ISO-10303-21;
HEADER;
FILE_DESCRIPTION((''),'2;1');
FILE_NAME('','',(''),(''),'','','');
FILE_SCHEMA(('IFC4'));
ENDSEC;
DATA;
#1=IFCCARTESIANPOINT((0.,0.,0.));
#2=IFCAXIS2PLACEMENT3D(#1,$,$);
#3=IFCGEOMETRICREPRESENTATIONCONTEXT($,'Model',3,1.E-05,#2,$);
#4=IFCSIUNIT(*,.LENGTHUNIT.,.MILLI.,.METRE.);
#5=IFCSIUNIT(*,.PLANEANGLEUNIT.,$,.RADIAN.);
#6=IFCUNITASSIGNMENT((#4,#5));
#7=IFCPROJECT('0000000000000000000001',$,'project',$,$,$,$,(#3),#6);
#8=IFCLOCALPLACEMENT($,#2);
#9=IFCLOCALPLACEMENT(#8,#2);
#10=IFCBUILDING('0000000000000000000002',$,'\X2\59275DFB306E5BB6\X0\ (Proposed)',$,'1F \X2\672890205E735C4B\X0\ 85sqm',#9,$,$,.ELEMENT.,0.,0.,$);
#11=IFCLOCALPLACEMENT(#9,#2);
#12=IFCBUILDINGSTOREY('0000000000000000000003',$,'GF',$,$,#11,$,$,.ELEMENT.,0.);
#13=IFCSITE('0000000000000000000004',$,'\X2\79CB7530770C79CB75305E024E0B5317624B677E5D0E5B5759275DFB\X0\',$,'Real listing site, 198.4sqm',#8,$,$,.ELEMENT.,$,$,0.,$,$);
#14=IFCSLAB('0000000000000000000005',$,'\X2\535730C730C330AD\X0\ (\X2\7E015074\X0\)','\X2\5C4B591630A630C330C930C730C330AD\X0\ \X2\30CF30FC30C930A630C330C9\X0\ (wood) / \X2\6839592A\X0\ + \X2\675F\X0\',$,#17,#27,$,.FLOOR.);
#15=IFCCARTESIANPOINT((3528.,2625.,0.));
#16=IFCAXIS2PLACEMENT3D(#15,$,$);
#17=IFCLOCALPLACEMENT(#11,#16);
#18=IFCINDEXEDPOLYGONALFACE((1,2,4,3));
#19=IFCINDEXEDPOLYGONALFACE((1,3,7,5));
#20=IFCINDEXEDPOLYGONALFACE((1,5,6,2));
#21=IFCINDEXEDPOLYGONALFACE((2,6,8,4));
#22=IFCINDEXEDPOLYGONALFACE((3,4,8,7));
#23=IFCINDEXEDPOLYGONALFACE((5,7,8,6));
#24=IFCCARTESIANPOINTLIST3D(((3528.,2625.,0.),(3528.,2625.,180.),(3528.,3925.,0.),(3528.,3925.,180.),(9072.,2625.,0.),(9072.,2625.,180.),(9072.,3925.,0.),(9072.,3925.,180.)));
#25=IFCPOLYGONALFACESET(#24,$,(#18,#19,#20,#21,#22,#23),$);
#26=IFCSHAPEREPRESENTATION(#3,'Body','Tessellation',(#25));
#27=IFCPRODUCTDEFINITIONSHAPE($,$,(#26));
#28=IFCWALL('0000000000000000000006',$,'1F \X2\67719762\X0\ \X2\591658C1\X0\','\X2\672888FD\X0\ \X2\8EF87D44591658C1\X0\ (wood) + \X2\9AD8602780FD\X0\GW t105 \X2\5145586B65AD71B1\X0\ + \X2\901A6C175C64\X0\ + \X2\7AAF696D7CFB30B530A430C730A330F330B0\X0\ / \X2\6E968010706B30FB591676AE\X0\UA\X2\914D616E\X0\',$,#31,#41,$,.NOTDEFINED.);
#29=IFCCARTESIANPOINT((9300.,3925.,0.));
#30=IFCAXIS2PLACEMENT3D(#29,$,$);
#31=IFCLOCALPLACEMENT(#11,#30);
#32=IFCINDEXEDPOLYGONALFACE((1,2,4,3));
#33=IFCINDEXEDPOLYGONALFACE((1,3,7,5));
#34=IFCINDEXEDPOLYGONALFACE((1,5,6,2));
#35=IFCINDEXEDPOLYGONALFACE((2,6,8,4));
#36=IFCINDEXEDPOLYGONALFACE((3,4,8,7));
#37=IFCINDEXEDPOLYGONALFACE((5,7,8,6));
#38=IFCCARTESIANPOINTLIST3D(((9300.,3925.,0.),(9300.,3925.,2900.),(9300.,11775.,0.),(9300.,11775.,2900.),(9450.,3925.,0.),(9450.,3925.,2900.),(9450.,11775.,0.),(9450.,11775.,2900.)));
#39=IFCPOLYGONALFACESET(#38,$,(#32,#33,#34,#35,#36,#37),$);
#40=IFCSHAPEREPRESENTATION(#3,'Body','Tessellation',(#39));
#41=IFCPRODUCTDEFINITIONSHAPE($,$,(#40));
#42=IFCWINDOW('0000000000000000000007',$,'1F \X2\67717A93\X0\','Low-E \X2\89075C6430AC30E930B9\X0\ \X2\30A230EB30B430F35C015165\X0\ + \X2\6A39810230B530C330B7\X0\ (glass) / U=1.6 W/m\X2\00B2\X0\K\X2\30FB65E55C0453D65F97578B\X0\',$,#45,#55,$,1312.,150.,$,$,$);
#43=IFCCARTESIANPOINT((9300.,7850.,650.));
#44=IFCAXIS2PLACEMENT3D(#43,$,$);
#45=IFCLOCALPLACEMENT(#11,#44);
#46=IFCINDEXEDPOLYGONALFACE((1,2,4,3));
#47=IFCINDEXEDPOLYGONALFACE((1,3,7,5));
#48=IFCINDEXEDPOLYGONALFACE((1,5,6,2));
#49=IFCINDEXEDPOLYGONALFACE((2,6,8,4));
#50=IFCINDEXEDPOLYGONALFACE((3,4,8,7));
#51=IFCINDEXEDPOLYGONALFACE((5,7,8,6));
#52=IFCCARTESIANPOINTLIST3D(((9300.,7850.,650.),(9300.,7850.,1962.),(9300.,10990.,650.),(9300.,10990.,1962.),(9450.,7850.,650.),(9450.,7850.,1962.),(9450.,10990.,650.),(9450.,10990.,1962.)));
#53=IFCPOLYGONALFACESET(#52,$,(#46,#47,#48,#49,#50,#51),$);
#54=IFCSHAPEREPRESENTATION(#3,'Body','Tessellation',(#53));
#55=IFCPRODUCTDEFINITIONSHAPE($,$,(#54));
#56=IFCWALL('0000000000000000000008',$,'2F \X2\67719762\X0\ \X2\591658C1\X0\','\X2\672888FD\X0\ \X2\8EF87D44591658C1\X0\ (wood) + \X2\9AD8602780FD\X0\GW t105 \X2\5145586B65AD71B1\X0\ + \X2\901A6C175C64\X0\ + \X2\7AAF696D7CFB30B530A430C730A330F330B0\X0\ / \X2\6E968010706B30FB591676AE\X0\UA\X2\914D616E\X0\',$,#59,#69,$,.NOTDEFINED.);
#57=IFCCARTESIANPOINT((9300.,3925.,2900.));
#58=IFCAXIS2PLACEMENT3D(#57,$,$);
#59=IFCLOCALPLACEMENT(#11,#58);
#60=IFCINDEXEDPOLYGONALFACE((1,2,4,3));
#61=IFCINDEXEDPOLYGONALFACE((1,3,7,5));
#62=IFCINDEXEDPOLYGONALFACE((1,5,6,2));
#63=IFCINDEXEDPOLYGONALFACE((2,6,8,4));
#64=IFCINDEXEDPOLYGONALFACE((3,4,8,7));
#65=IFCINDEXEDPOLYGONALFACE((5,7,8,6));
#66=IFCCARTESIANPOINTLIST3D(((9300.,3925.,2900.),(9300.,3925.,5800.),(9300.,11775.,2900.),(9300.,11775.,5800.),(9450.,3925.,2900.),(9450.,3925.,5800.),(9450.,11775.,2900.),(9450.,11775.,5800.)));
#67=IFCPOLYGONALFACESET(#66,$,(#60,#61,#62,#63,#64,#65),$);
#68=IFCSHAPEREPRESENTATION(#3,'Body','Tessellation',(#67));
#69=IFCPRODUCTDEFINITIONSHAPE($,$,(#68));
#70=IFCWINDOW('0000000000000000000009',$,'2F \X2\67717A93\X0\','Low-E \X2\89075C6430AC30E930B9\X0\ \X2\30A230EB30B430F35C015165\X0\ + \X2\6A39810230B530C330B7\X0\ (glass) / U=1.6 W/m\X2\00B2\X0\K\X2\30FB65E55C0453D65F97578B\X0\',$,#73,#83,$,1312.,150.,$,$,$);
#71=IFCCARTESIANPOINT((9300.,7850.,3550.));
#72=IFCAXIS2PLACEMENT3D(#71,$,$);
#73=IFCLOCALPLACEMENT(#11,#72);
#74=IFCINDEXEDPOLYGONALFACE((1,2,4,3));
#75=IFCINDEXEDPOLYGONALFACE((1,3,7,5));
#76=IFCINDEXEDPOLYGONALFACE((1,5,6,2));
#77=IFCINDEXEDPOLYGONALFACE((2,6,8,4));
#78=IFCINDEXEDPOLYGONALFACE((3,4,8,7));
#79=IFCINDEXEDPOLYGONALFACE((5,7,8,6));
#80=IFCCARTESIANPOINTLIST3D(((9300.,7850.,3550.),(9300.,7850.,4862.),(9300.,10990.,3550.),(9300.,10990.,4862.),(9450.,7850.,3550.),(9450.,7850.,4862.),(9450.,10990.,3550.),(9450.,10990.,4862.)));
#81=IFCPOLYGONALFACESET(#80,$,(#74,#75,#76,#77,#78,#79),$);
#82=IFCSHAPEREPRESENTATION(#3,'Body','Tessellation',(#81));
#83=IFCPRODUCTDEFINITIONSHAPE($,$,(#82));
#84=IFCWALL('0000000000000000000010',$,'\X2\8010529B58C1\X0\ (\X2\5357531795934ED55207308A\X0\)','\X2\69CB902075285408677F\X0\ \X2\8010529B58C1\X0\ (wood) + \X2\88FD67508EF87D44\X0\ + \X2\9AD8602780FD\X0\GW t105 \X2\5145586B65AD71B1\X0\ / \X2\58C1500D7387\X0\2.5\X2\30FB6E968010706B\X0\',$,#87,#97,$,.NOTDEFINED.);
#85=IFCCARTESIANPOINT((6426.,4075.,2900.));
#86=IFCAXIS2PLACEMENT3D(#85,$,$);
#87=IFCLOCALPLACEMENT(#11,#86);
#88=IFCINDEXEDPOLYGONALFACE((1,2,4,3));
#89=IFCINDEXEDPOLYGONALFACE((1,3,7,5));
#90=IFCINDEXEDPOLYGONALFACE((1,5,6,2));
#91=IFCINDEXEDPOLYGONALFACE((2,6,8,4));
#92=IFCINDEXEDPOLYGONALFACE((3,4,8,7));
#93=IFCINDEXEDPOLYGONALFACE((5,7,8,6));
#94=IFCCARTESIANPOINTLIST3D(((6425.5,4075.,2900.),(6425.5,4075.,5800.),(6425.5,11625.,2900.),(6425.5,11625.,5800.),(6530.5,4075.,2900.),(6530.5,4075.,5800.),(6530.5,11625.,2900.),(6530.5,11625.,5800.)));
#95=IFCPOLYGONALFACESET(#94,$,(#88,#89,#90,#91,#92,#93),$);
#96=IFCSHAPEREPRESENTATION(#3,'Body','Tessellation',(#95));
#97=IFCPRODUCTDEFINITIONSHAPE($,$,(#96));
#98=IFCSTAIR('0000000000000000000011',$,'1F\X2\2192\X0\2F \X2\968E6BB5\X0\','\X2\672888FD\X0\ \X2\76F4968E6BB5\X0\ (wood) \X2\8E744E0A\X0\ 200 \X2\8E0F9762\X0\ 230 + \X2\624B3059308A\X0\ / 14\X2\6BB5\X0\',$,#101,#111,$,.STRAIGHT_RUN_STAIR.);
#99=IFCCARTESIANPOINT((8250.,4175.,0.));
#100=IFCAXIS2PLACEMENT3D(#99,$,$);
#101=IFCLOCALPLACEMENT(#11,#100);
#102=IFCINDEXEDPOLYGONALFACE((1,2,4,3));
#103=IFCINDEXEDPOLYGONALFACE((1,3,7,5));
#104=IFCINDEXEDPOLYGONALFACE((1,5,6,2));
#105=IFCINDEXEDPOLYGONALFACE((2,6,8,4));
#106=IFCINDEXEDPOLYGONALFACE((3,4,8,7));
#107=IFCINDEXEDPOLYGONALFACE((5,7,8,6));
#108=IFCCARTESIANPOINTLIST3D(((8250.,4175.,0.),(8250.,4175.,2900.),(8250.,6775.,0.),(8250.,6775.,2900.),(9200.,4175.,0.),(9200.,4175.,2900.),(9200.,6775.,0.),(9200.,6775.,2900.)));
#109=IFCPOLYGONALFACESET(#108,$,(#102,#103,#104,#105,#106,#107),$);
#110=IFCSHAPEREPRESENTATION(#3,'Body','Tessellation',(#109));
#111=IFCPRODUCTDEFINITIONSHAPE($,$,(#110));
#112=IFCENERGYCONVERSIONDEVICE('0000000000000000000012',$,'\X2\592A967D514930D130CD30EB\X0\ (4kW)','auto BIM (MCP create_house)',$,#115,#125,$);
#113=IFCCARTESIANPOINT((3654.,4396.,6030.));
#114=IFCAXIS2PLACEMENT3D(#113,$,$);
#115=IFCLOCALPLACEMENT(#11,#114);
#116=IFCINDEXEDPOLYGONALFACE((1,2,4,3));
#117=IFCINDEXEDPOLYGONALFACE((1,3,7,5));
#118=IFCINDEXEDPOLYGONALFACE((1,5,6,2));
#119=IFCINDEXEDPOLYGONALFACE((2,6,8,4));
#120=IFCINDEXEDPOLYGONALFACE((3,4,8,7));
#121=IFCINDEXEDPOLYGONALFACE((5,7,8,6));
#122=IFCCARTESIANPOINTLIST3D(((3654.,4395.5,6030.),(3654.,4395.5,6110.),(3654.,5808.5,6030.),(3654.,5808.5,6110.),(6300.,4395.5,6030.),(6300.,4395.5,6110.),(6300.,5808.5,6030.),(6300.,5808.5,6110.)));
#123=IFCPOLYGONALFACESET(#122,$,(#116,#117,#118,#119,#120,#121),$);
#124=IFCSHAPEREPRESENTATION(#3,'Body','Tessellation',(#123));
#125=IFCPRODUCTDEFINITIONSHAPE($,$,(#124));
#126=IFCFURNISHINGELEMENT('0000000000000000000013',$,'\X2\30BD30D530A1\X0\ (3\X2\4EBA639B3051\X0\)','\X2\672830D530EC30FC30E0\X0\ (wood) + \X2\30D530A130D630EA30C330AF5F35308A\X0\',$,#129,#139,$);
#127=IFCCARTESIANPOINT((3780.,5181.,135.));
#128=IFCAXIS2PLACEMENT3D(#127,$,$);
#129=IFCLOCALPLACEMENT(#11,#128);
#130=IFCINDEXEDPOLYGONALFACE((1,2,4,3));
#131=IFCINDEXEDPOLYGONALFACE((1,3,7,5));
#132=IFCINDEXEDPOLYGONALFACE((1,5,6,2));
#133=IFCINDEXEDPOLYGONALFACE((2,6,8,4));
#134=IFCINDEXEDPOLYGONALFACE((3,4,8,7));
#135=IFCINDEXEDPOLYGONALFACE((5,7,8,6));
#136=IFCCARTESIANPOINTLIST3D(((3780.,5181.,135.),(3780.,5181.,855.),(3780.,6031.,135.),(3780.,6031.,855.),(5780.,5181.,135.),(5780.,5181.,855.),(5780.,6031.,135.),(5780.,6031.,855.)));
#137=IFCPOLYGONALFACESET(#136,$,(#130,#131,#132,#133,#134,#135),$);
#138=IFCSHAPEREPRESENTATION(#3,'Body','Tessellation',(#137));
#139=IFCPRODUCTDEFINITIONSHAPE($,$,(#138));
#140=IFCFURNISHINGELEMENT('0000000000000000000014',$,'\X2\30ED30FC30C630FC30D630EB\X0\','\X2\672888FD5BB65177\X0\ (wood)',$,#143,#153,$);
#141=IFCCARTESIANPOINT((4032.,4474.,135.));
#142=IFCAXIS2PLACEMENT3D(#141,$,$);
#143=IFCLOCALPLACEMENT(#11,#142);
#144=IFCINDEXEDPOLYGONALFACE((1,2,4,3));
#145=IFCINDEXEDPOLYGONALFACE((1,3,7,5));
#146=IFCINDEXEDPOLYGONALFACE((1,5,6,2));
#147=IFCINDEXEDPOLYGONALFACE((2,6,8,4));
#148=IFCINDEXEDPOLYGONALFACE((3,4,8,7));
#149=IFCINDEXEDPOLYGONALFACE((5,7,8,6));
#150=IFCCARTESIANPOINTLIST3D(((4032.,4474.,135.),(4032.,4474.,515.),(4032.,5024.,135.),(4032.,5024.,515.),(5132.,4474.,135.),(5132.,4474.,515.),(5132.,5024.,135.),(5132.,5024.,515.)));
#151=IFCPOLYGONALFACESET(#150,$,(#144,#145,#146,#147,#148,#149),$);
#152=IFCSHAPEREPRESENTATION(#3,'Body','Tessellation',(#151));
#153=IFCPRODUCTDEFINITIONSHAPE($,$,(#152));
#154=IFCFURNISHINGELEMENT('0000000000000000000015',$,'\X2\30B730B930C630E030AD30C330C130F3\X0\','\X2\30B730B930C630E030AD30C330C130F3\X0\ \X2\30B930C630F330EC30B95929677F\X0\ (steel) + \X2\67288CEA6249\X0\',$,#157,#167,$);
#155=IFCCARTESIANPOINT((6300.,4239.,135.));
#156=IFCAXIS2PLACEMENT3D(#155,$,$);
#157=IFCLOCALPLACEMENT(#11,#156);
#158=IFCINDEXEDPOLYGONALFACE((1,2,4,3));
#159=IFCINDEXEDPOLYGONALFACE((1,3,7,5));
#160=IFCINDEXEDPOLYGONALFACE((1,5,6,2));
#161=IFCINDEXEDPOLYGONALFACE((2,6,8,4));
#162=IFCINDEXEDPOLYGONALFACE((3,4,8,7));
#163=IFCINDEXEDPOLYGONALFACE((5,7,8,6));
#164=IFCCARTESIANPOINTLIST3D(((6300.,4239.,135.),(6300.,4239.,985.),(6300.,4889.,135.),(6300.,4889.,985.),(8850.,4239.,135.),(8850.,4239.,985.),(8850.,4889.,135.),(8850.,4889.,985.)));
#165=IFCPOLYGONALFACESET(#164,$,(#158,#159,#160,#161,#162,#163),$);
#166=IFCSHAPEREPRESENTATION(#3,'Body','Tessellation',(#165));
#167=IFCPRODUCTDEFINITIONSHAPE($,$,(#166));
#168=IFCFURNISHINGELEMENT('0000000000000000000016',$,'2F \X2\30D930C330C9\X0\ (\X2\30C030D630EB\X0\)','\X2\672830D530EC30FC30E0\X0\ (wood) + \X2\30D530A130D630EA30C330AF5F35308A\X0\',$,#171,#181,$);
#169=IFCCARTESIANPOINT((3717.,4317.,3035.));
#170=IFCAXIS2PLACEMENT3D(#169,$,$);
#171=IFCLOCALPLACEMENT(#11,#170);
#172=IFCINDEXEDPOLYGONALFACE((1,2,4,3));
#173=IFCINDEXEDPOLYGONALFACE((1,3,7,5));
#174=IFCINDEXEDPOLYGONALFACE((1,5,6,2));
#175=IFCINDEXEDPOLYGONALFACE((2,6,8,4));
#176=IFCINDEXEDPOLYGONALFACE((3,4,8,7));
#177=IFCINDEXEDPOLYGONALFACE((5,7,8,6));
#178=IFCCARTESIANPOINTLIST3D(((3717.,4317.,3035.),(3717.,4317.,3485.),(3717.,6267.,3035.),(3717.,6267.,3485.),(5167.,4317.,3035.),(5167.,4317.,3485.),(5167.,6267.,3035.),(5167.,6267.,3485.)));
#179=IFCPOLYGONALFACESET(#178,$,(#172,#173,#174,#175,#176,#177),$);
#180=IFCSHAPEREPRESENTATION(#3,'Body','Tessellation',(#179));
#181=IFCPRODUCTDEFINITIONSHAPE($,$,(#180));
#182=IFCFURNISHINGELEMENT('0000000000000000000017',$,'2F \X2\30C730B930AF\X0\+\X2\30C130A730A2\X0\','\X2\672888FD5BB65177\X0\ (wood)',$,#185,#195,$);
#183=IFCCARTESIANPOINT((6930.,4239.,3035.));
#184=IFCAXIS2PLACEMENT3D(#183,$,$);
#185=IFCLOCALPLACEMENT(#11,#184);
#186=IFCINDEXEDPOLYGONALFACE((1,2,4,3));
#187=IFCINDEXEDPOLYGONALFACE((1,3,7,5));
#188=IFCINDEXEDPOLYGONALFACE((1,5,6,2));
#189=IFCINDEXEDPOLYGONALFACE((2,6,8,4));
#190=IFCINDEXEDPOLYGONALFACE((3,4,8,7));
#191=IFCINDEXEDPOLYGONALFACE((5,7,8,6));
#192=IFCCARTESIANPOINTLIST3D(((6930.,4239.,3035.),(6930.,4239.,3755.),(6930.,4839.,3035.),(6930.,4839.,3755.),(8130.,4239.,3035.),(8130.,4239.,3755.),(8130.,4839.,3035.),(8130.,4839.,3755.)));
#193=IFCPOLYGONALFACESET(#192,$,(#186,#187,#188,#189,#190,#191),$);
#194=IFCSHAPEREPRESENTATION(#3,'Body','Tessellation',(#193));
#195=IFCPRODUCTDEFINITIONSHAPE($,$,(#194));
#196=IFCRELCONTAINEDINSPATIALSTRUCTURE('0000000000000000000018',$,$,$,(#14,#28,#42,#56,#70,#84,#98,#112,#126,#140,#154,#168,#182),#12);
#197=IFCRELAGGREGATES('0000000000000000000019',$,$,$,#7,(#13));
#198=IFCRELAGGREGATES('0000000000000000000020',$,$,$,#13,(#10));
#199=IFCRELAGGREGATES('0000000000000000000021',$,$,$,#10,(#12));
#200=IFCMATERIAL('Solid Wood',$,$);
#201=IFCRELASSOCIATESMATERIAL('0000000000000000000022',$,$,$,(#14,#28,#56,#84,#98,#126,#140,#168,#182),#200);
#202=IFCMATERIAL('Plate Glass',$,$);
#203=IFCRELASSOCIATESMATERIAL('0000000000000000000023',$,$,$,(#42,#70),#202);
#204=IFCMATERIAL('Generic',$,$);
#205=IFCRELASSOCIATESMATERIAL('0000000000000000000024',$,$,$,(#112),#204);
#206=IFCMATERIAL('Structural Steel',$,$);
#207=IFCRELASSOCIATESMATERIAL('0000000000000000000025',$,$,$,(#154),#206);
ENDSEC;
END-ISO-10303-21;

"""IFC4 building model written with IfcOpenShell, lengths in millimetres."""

from ifc_helpers import new_model, si_unit, frame, frame_2d, origin, place, context, project, spatial, rectangle, extrude, material, element, fill, save


model = new_model("IFC4")

# Units and contexts
model_context = context("Model", 3, precision=1e-05, world=origin())
ifc_project = project(units=[si_unit("LENGTHUNIT", "METRE", prefix="MILLI"), si_unit("PLANEANGLEUNIT", "RADIAN")], contexts=[model_context])

# Site, building, storey
site_placement = place(None, origin())
site = spatial("IfcSite", under=ifc_project, at=site_placement, Name="秋田県秋田市下北手松崎字大巻", ObjectType="Real listing site, 198.4sqm", CompositionType="ELEMENT", RefElevation=0.0)
building_placement = place(site_placement, origin())
building = spatial("IfcBuilding", under=site, at=building_placement, Name="大巻の家 (Proposed)", ObjectType="1F 木造平屋 85sqm", CompositionType="ELEMENT", ElevationOfRefHeight=0.0, ElevationOfTerrain=0.0)
storey_placement = place(building_placement, origin())
storey = spatial("IfcBuildingStorey", under=building, at=storey_placement, Name="GF", CompositionType="ELEMENT", Elevation=0.0)

# Slab
ifc_material_1 = material(Name="Solid Wood")
slab_placement = place(storey_placement, frame((3528.0, 2625.0, 0.0)))
element("IfcSlab", 1, at=slab_placement, inside=storey, material=ifc_material_1, Name="南デッキ (縁側)", Description="屋外ウッドデッキ ハードウッド (wood) / 根太 + 束", PredefinedType="FLOOR", context=model_context, shape_type="SweptSolid", body=[
    extrude(rectangle(XDim=5544.0, YDim=1300.0, at=frame_2d((2772.0, 650.0))), frame((3528.0, 2625.0, 0.0)), (0.0, 0.0, 1.0), 180.0),
])

# Wall, opening, window
wall_1_placement = place(storey_placement, frame((9300.0, 3925.0, 0.0)))
wall_1 = element("IfcWall", 2, at=wall_1_placement, inside=storey, material=ifc_material_1, Name="1F 東面 外壁", Description="木製 軸組外壁 (wood) + 高性能GW t105 充填断熱 + 通気層 + 窯業系サイディング / 準耐火・外皮UA配慮", PredefinedType="NOTDEFINED", context=model_context, shape_type="SweptSolid", body=[
    extrude(rectangle(XDim=150.0, YDim=7850.0, at=frame_2d((75.0, 3925.0))), frame((9300.0, 3925.0, 0.0)), (0.0, 0.0, 1.0), 2900.0),
])
opening_1_placement = place(storey_placement, frame((9300.0, 7850.0, 650.0)))
opening_1 = element("IfcOpeningElement", 3, at=opening_1_placement, cuts=wall_1, PredefinedType="NOTDEFINED", context=model_context, shape_type="SweptSolid", body=[
    extrude(rectangle(XDim=150.0, YDim=3140.0, at=frame_2d((75.0, 1570.0))), frame((9300.0, 7850.0, 650.0)), (0.0, 0.0, 1.0), 1312.0),
])
ifc_material_2 = material(Name="Plate Glass")
window_1_placement = place(storey_placement, frame((9300.0, 7850.0, 650.0)))
window_1 = element("IfcWindow", 4, at=window_1_placement, inside=storey, material=ifc_material_2, Name="1F 東窓", Description="Low-E 複層ガラス アルゴン封入 + 樹脂サッシ (glass) / U=1.6 W/m²K・日射取得型", OverallHeight=1312.0, OverallWidth=150.0, context=model_context, shape_type="SweptSolid", body=[
    extrude(rectangle(XDim=150.0, YDim=3140.0, at=frame_2d((75.0, 1570.0))), frame((9300.0, 7850.0, 650.0)), (0.0, 0.0, 1.0), 1312.0),
])
fill(opening_1, window_1)

# Wall, opening, window
wall_2_placement = place(storey_placement, frame((9300.0, 3925.0, 2900.0)))
wall_2 = element("IfcWall", 5, at=wall_2_placement, inside=storey, material=ifc_material_1, Name="2F 東面 外壁", Description="木製 軸組外壁 (wood) + 高性能GW t105 充填断熱 + 通気層 + 窯業系サイディング / 準耐火・外皮UA配慮", PredefinedType="NOTDEFINED", context=model_context, shape_type="SweptSolid", body=[
    extrude(rectangle(XDim=150.0, YDim=7850.0, at=frame_2d((75.0, 3925.0))), frame((9300.0, 3925.0, 2900.0)), (0.0, 0.0, 1.0), 2900.0),
])
opening_2_placement = place(storey_placement, frame((9300.0, 7850.0, 3550.0)))
opening_2 = element("IfcOpeningElement", 6, at=opening_2_placement, cuts=wall_2, PredefinedType="NOTDEFINED", context=model_context, shape_type="SweptSolid", body=[
    extrude(rectangle(XDim=150.0, YDim=3140.0, at=frame_2d((75.0, 1570.0))), frame((9300.0, 7850.0, 3550.0)), (0.0, 0.0, 1.0), 1312.0),
])
window_2_placement = place(storey_placement, frame((9300.0, 7850.0, 3550.0)))
window_2 = element("IfcWindow", 7, at=window_2_placement, inside=storey, material=ifc_material_2, Name="2F 東窓", Description="Low-E 複層ガラス アルゴン封入 + 樹脂サッシ (glass) / U=1.6 W/m²K・日射取得型", OverallHeight=1312.0, OverallWidth=150.0, context=model_context, shape_type="SweptSolid", body=[
    extrude(rectangle(XDim=150.0, YDim=3140.0, at=frame_2d((75.0, 1570.0))), frame((9300.0, 7850.0, 3550.0)), (0.0, 0.0, 1.0), 1312.0),
])
fill(opening_2, window_2)

# Wall
wall_3_placement = place(storey_placement, frame((6426.0, 4075.0, 2900.0)))
element("IfcWall", 8, at=wall_3_placement, inside=storey, material=ifc_material_1, Name="耐力壁 (南北間仕切り)", Description="構造用合板 耐力壁 (wood) + 製材軸組 + 高性能GW t105 充填断熱 / 壁倍率2.5・準耐火", PredefinedType="NOTDEFINED", context=model_context, shape_type="SweptSolid", body=[
    extrude(rectangle(XDim=105.0, YDim=7550.0, at=frame_2d((52.0, 3775.0))), frame((6426.0, 4075.0, 2900.0)), (0.0, 0.0, 1.0), 2900.0),
])

# Stair
stair_placement = place(storey_placement, frame((8250.0, 4175.0, 0.0)))
element("IfcStair", 9, at=stair_placement, inside=storey, material=ifc_material_1, Name="1F→2F 階段", Description="木製 直階段 (wood) 蹴上 200 踏面 230 + 手すり / 14段", PredefinedType="STRAIGHT_RUN_STAIR", context=model_context, shape_type="SweptSolid", body=[
    extrude(rectangle(XDim=950.0, YDim=2600.0, at=frame_2d((475.0, 1300.0))), frame((8250.0, 4175.0, 0.0)), (0.0, 0.0, 1.0), 2900.0),
])

# Energy conversion device
ifc_material_3 = material(Name="Generic")
energy_conversion_device_placement = place(storey_placement, frame((3654.0, 4396.0, 6030.0)))
element("IfcEnergyConversionDevice", 10, at=energy_conversion_device_placement, inside=storey, material=ifc_material_3, Name="太陽光パネル (4kW)", Description="auto BIM (MCP create_house)", context=model_context, shape_type="SweptSolid", body=[
    extrude(rectangle(XDim=2646.0, YDim=1413.0, at=frame_2d((1323.0, 706.0))), frame((3654.0, 4396.0, 6030.0)), (0.0, 0.0, 1.0), 80.0),
])

# Furnishing elements
furnishing_1_placement = place(storey_placement, frame((3780.0, 5181.0, 135.0)))
element("IfcFurnishingElement", 11, at=furnishing_1_placement, inside=storey, material=ifc_material_1, Name="ソファ (3人掛け)", Description="木フレーム (wood) + ファブリック張り", context=model_context, shape_type="SweptSolid", body=[
    extrude(rectangle(XDim=2000.0, YDim=850.0, at=frame_2d((1000.0, 425.0))), frame((3780.0, 5181.0, 135.0)), (0.0, 0.0, 1.0), 720.0),
])
furnishing_2_placement = place(storey_placement, frame((4032.0, 4474.0, 135.0)))
element("IfcFurnishingElement", 12, at=furnishing_2_placement, inside=storey, material=ifc_material_1, Name="ローテーブル", Description="木製家具 (wood)", context=model_context, shape_type="SweptSolid", body=[
    extrude(rectangle(XDim=1100.0, YDim=550.0, at=frame_2d((550.0, 275.0))), frame((4032.0, 4474.0, 135.0)), (0.0, 0.0, 1.0), 380.0),
])
ifc_material_4 = material(Name="Structural Steel")
furnishing_3_placement = place(storey_placement, frame((6300.0, 4239.0, 135.0)))
element("IfcFurnishingElement", 13, at=furnishing_3_placement, inside=storey, material=ifc_material_4, Name="システムキッチン", Description="システムキッチン ステンレス天板 (steel) + 木質扉", context=model_context, shape_type="SweptSolid", body=[
    extrude(rectangle(XDim=2550.0, YDim=650.0, at=frame_2d((1275.0, 325.0))), frame((6300.0, 4239.0, 135.0)), (0.0, 0.0, 1.0), 850.0),
])
furnishing_4_placement = place(storey_placement, frame((3717.0, 4317.0, 3035.0)))
element("IfcFurnishingElement", 14, at=furnishing_4_placement, inside=storey, material=ifc_material_1, Name="2F ベッド (ダブル)", Description="木フレーム (wood) + ファブリック張り", context=model_context, shape_type="SweptSolid", body=[
    extrude(rectangle(XDim=1450.0, YDim=1950.0, at=frame_2d((725.0, 975.0))), frame((3717.0, 4317.0, 3035.0)), (0.0, 0.0, 1.0), 450.0),
])
furnishing_5_placement = place(storey_placement, frame((6930.0, 4239.0, 3035.0)))
element("IfcFurnishingElement", 15, at=furnishing_5_placement, inside=storey, material=ifc_material_1, Name="2F デスク+チェア", Description="木製家具 (wood)", context=model_context, shape_type="SweptSolid", body=[
    extrude(rectangle(XDim=1200.0, YDim=600.0, at=frame_2d((600.0, 300.0))), frame((6930.0, 4239.0, 3035.0)), (0.0, 0.0, 1.0), 720.0),
])

save(model, "model.ifc")
